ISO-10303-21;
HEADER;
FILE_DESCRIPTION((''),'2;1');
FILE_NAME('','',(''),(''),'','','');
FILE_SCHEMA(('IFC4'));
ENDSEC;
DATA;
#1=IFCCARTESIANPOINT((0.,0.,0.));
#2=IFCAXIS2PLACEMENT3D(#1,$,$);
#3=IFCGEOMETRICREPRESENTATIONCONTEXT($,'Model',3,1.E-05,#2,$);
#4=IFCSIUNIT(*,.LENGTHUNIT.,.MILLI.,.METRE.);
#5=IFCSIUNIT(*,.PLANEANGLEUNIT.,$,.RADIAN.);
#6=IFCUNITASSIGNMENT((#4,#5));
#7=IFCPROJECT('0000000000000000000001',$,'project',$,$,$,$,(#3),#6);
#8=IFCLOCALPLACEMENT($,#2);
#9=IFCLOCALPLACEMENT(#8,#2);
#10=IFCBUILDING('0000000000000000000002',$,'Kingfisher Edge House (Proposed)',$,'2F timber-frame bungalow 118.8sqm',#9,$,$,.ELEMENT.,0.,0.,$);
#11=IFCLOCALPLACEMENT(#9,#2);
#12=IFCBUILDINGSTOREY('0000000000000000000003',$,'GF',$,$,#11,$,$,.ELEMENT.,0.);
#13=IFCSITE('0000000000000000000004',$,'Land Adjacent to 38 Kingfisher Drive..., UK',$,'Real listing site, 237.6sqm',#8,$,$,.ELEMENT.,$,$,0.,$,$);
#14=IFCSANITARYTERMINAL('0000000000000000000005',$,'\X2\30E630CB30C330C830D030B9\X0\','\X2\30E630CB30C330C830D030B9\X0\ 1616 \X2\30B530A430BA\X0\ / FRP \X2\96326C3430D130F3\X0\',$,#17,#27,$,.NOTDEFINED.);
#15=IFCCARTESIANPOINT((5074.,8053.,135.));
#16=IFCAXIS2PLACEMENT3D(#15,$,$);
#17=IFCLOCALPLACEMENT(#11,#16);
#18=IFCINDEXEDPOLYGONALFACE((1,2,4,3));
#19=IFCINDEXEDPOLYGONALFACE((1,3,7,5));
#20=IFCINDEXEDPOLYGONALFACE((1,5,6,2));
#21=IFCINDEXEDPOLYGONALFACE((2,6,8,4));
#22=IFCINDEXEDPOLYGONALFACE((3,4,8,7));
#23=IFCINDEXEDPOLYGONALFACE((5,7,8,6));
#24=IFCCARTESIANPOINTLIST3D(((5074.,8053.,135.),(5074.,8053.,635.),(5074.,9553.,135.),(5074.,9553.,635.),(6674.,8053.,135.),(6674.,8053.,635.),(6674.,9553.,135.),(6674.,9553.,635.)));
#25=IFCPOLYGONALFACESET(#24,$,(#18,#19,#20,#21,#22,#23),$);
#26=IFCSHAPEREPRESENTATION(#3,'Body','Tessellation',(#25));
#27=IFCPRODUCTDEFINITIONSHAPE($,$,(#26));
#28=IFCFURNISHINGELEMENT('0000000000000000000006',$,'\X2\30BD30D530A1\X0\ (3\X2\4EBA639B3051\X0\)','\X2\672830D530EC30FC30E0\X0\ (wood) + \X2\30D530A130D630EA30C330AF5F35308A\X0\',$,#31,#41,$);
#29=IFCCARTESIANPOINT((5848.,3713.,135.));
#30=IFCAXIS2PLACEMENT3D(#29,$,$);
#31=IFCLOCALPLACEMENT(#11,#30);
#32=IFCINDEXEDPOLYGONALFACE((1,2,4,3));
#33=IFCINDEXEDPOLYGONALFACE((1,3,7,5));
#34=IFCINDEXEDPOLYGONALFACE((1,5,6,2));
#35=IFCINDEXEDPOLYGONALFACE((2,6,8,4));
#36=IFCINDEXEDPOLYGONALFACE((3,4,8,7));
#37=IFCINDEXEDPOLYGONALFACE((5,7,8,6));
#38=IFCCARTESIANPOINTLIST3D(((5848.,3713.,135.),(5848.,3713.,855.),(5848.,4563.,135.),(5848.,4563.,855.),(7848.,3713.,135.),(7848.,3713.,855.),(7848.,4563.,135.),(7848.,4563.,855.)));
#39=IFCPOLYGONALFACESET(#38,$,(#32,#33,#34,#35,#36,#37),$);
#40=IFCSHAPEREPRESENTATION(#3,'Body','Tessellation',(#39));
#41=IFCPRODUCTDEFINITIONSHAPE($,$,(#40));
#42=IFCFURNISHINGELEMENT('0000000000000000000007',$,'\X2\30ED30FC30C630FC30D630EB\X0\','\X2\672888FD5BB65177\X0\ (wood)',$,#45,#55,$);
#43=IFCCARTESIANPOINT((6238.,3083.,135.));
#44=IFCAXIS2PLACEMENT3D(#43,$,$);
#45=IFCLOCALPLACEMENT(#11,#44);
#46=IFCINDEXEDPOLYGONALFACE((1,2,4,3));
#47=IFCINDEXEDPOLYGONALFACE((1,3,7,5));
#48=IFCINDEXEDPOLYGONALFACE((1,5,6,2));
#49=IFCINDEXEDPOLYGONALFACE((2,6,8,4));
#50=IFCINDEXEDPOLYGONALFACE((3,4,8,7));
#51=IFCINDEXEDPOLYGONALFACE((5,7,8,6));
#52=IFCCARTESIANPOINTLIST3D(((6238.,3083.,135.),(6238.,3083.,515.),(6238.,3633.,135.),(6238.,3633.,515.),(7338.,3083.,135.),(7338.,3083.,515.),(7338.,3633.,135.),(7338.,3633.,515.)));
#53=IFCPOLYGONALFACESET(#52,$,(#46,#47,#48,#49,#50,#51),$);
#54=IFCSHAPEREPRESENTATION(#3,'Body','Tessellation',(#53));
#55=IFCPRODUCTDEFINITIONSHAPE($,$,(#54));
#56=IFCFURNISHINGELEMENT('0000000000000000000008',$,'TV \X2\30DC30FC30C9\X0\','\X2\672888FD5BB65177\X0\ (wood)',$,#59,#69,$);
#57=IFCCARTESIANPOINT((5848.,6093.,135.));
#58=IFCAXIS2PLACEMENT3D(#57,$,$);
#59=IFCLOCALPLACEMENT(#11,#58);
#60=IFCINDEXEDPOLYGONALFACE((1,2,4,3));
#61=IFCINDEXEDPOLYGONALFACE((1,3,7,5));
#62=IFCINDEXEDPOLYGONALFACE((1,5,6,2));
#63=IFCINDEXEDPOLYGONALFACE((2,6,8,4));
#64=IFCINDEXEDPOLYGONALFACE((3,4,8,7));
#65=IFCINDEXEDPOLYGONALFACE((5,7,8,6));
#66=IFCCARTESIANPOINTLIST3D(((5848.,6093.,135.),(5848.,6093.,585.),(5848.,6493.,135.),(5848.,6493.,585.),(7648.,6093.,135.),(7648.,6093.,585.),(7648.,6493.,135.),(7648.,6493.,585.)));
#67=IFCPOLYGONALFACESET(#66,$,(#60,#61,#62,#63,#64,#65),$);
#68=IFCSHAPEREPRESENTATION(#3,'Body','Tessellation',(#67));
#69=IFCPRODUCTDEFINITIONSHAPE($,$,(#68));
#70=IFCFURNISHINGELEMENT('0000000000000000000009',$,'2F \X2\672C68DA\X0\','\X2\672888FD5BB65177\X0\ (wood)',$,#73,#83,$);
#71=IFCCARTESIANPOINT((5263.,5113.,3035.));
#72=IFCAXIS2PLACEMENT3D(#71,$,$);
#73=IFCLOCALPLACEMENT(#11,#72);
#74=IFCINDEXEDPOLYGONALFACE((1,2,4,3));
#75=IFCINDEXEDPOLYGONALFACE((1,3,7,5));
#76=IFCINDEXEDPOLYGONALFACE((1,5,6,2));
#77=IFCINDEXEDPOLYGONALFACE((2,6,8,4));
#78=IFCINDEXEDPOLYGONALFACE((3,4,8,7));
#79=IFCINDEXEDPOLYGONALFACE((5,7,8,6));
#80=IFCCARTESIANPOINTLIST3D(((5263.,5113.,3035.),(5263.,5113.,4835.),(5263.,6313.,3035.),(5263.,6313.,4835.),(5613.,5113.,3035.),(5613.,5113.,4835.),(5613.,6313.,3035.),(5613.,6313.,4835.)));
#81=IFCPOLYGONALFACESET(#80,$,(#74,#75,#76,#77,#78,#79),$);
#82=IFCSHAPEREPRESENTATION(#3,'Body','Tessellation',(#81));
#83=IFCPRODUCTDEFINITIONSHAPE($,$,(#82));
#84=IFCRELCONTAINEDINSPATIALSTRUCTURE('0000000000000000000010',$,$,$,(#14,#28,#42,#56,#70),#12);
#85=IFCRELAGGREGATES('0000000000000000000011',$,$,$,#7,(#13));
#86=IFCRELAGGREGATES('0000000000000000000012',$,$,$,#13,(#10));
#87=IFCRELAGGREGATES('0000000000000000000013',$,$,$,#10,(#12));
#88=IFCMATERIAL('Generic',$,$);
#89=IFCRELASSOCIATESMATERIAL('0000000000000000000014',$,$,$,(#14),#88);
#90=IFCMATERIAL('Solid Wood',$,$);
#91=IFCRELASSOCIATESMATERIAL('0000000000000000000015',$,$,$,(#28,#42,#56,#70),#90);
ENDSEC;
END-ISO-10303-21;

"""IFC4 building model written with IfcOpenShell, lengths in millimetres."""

from ifc_helpers import new_model, si_unit, frame, frame_2d, origin, place, context, project, spatial, rectangle, extrude, material, element, save


model = new_model("IFC4")

# Units and contexts
model_context = context("Model", 3, precision=1e-05, world=origin())
ifc_project = project(units=[si_unit("LENGTHUNIT", "METRE", prefix="MILLI"), si_unit("PLANEANGLEUNIT", "RADIAN")], contexts=[model_context])

# Site, building, storey
site_placement = place(None, origin())
site = spatial("IfcSite", under=ifc_project, at=site_placement, Name="Land Adjacent to 38 Kingfisher Drive..., UK", ObjectType="Real listing site, 237.6sqm", CompositionType="ELEMENT", RefElevation=0.0)
building_placement = place(site_placement, origin())
building = spatial("IfcBuilding", under=site, at=building_placement, Name="Kingfisher Edge House (Proposed)", ObjectType="2F timber-frame bungalow 118.8sqm", CompositionType="ELEMENT", ElevationOfRefHeight=0.0, ElevationOfTerrain=0.0)
storey_placement = place(building_placement, origin())
storey = spatial("IfcBuildingStorey", under=building, at=storey_placement, Name="GF", CompositionType="ELEMENT", Elevation=0.0)

# Shared definitions
ifc_material_1 = material(Name="Solid Wood")

# Sanitary terminal
ifc_material_2 = material(Name="Generic")
sanitary_terminal_placement = place(storey_placement, frame((5074.0, 8053.0, 135.0)))
element("IfcSanitaryTerminal", 1, at=sanitary_terminal_placement, inside=storey, material=ifc_material_2, Name="ユニットバス", Description="ユニットバス 1616 サイズ / FRP 防水パン", PredefinedType="NOTDEFINED", context=model_context, shape_type="SweptSolid", body=[
    extrude(rectangle(XDim=1600.0, YDim=1500.0, at=frame_2d((800.0, 750.0))), frame((5074.0, 8053.0, 135.0)), (0.0, 0.0, 1.0), 500.0),
])

# Furnishing elements
furnishing_1_placement = place(storey_placement, frame((5848.0, 3713.0, 135.0)))
element("IfcFurnishingElement", 2, at=furnishing_1_placement, inside=storey, material=ifc_material_1, Name="ソファ (3人掛け)", Description="木フレーム (wood) + ファブリック張り", context=model_context, shape_type="SweptSolid", body=[
    extrude(rectangle(XDim=2000.0, YDim=850.0, at=frame_2d((1000.0, 425.0))), frame((5848.0, 3713.0, 135.0)), (0.0, 0.0, 1.0), 720.0),
])
furnishing_2_placement = place(storey_placement, frame((6238.0, 3083.0, 135.0)))
element("IfcFurnishingElement", 3, at=furnishing_2_placement, inside=storey, material=ifc_material_1, Name="ローテーブル", Description="木製家具 (wood)", context=model_context, shape_type="SweptSolid", body=[
    extrude(rectangle(XDim=1100.0, YDim=550.0, at=frame_2d((550.0, 275.0))), frame((6238.0, 3083.0, 135.0)), (0.0, 0.0, 1.0), 380.0),
])
furnishing_3_placement = place(storey_placement, frame((5848.0, 6093.0, 135.0)))
element("IfcFurnishingElement", 4, at=furnishing_3_placement, inside=storey, material=ifc_material_1, Name="TV ボード", Description="木製家具 (wood)", context=model_context, shape_type="SweptSolid", body=[
    extrude(rectangle(XDim=1800.0, YDim=400.0, at=frame_2d((900.0, 200.0))), frame((5848.0, 6093.0, 135.0)), (0.0, 0.0, 1.0), 450.0),
])
furnishing_4_placement = place(storey_placement, frame((5263.0, 5113.0, 3035.0)))
element("IfcFurnishingElement", 5, at=furnishing_4_placement, inside=storey, material=ifc_material_1, Name="2F 本棚", Description="木製家具 (wood)", context=model_context, shape_type="SweptSolid", body=[
    extrude(rectangle(XDim=350.0, YDim=1200.0, at=frame_2d((175.0, 600.0))), frame((5263.0, 5113.0, 3035.0)), (0.0, 0.0, 1.0), 1800.0),
])

save(model, "model.ifc")
